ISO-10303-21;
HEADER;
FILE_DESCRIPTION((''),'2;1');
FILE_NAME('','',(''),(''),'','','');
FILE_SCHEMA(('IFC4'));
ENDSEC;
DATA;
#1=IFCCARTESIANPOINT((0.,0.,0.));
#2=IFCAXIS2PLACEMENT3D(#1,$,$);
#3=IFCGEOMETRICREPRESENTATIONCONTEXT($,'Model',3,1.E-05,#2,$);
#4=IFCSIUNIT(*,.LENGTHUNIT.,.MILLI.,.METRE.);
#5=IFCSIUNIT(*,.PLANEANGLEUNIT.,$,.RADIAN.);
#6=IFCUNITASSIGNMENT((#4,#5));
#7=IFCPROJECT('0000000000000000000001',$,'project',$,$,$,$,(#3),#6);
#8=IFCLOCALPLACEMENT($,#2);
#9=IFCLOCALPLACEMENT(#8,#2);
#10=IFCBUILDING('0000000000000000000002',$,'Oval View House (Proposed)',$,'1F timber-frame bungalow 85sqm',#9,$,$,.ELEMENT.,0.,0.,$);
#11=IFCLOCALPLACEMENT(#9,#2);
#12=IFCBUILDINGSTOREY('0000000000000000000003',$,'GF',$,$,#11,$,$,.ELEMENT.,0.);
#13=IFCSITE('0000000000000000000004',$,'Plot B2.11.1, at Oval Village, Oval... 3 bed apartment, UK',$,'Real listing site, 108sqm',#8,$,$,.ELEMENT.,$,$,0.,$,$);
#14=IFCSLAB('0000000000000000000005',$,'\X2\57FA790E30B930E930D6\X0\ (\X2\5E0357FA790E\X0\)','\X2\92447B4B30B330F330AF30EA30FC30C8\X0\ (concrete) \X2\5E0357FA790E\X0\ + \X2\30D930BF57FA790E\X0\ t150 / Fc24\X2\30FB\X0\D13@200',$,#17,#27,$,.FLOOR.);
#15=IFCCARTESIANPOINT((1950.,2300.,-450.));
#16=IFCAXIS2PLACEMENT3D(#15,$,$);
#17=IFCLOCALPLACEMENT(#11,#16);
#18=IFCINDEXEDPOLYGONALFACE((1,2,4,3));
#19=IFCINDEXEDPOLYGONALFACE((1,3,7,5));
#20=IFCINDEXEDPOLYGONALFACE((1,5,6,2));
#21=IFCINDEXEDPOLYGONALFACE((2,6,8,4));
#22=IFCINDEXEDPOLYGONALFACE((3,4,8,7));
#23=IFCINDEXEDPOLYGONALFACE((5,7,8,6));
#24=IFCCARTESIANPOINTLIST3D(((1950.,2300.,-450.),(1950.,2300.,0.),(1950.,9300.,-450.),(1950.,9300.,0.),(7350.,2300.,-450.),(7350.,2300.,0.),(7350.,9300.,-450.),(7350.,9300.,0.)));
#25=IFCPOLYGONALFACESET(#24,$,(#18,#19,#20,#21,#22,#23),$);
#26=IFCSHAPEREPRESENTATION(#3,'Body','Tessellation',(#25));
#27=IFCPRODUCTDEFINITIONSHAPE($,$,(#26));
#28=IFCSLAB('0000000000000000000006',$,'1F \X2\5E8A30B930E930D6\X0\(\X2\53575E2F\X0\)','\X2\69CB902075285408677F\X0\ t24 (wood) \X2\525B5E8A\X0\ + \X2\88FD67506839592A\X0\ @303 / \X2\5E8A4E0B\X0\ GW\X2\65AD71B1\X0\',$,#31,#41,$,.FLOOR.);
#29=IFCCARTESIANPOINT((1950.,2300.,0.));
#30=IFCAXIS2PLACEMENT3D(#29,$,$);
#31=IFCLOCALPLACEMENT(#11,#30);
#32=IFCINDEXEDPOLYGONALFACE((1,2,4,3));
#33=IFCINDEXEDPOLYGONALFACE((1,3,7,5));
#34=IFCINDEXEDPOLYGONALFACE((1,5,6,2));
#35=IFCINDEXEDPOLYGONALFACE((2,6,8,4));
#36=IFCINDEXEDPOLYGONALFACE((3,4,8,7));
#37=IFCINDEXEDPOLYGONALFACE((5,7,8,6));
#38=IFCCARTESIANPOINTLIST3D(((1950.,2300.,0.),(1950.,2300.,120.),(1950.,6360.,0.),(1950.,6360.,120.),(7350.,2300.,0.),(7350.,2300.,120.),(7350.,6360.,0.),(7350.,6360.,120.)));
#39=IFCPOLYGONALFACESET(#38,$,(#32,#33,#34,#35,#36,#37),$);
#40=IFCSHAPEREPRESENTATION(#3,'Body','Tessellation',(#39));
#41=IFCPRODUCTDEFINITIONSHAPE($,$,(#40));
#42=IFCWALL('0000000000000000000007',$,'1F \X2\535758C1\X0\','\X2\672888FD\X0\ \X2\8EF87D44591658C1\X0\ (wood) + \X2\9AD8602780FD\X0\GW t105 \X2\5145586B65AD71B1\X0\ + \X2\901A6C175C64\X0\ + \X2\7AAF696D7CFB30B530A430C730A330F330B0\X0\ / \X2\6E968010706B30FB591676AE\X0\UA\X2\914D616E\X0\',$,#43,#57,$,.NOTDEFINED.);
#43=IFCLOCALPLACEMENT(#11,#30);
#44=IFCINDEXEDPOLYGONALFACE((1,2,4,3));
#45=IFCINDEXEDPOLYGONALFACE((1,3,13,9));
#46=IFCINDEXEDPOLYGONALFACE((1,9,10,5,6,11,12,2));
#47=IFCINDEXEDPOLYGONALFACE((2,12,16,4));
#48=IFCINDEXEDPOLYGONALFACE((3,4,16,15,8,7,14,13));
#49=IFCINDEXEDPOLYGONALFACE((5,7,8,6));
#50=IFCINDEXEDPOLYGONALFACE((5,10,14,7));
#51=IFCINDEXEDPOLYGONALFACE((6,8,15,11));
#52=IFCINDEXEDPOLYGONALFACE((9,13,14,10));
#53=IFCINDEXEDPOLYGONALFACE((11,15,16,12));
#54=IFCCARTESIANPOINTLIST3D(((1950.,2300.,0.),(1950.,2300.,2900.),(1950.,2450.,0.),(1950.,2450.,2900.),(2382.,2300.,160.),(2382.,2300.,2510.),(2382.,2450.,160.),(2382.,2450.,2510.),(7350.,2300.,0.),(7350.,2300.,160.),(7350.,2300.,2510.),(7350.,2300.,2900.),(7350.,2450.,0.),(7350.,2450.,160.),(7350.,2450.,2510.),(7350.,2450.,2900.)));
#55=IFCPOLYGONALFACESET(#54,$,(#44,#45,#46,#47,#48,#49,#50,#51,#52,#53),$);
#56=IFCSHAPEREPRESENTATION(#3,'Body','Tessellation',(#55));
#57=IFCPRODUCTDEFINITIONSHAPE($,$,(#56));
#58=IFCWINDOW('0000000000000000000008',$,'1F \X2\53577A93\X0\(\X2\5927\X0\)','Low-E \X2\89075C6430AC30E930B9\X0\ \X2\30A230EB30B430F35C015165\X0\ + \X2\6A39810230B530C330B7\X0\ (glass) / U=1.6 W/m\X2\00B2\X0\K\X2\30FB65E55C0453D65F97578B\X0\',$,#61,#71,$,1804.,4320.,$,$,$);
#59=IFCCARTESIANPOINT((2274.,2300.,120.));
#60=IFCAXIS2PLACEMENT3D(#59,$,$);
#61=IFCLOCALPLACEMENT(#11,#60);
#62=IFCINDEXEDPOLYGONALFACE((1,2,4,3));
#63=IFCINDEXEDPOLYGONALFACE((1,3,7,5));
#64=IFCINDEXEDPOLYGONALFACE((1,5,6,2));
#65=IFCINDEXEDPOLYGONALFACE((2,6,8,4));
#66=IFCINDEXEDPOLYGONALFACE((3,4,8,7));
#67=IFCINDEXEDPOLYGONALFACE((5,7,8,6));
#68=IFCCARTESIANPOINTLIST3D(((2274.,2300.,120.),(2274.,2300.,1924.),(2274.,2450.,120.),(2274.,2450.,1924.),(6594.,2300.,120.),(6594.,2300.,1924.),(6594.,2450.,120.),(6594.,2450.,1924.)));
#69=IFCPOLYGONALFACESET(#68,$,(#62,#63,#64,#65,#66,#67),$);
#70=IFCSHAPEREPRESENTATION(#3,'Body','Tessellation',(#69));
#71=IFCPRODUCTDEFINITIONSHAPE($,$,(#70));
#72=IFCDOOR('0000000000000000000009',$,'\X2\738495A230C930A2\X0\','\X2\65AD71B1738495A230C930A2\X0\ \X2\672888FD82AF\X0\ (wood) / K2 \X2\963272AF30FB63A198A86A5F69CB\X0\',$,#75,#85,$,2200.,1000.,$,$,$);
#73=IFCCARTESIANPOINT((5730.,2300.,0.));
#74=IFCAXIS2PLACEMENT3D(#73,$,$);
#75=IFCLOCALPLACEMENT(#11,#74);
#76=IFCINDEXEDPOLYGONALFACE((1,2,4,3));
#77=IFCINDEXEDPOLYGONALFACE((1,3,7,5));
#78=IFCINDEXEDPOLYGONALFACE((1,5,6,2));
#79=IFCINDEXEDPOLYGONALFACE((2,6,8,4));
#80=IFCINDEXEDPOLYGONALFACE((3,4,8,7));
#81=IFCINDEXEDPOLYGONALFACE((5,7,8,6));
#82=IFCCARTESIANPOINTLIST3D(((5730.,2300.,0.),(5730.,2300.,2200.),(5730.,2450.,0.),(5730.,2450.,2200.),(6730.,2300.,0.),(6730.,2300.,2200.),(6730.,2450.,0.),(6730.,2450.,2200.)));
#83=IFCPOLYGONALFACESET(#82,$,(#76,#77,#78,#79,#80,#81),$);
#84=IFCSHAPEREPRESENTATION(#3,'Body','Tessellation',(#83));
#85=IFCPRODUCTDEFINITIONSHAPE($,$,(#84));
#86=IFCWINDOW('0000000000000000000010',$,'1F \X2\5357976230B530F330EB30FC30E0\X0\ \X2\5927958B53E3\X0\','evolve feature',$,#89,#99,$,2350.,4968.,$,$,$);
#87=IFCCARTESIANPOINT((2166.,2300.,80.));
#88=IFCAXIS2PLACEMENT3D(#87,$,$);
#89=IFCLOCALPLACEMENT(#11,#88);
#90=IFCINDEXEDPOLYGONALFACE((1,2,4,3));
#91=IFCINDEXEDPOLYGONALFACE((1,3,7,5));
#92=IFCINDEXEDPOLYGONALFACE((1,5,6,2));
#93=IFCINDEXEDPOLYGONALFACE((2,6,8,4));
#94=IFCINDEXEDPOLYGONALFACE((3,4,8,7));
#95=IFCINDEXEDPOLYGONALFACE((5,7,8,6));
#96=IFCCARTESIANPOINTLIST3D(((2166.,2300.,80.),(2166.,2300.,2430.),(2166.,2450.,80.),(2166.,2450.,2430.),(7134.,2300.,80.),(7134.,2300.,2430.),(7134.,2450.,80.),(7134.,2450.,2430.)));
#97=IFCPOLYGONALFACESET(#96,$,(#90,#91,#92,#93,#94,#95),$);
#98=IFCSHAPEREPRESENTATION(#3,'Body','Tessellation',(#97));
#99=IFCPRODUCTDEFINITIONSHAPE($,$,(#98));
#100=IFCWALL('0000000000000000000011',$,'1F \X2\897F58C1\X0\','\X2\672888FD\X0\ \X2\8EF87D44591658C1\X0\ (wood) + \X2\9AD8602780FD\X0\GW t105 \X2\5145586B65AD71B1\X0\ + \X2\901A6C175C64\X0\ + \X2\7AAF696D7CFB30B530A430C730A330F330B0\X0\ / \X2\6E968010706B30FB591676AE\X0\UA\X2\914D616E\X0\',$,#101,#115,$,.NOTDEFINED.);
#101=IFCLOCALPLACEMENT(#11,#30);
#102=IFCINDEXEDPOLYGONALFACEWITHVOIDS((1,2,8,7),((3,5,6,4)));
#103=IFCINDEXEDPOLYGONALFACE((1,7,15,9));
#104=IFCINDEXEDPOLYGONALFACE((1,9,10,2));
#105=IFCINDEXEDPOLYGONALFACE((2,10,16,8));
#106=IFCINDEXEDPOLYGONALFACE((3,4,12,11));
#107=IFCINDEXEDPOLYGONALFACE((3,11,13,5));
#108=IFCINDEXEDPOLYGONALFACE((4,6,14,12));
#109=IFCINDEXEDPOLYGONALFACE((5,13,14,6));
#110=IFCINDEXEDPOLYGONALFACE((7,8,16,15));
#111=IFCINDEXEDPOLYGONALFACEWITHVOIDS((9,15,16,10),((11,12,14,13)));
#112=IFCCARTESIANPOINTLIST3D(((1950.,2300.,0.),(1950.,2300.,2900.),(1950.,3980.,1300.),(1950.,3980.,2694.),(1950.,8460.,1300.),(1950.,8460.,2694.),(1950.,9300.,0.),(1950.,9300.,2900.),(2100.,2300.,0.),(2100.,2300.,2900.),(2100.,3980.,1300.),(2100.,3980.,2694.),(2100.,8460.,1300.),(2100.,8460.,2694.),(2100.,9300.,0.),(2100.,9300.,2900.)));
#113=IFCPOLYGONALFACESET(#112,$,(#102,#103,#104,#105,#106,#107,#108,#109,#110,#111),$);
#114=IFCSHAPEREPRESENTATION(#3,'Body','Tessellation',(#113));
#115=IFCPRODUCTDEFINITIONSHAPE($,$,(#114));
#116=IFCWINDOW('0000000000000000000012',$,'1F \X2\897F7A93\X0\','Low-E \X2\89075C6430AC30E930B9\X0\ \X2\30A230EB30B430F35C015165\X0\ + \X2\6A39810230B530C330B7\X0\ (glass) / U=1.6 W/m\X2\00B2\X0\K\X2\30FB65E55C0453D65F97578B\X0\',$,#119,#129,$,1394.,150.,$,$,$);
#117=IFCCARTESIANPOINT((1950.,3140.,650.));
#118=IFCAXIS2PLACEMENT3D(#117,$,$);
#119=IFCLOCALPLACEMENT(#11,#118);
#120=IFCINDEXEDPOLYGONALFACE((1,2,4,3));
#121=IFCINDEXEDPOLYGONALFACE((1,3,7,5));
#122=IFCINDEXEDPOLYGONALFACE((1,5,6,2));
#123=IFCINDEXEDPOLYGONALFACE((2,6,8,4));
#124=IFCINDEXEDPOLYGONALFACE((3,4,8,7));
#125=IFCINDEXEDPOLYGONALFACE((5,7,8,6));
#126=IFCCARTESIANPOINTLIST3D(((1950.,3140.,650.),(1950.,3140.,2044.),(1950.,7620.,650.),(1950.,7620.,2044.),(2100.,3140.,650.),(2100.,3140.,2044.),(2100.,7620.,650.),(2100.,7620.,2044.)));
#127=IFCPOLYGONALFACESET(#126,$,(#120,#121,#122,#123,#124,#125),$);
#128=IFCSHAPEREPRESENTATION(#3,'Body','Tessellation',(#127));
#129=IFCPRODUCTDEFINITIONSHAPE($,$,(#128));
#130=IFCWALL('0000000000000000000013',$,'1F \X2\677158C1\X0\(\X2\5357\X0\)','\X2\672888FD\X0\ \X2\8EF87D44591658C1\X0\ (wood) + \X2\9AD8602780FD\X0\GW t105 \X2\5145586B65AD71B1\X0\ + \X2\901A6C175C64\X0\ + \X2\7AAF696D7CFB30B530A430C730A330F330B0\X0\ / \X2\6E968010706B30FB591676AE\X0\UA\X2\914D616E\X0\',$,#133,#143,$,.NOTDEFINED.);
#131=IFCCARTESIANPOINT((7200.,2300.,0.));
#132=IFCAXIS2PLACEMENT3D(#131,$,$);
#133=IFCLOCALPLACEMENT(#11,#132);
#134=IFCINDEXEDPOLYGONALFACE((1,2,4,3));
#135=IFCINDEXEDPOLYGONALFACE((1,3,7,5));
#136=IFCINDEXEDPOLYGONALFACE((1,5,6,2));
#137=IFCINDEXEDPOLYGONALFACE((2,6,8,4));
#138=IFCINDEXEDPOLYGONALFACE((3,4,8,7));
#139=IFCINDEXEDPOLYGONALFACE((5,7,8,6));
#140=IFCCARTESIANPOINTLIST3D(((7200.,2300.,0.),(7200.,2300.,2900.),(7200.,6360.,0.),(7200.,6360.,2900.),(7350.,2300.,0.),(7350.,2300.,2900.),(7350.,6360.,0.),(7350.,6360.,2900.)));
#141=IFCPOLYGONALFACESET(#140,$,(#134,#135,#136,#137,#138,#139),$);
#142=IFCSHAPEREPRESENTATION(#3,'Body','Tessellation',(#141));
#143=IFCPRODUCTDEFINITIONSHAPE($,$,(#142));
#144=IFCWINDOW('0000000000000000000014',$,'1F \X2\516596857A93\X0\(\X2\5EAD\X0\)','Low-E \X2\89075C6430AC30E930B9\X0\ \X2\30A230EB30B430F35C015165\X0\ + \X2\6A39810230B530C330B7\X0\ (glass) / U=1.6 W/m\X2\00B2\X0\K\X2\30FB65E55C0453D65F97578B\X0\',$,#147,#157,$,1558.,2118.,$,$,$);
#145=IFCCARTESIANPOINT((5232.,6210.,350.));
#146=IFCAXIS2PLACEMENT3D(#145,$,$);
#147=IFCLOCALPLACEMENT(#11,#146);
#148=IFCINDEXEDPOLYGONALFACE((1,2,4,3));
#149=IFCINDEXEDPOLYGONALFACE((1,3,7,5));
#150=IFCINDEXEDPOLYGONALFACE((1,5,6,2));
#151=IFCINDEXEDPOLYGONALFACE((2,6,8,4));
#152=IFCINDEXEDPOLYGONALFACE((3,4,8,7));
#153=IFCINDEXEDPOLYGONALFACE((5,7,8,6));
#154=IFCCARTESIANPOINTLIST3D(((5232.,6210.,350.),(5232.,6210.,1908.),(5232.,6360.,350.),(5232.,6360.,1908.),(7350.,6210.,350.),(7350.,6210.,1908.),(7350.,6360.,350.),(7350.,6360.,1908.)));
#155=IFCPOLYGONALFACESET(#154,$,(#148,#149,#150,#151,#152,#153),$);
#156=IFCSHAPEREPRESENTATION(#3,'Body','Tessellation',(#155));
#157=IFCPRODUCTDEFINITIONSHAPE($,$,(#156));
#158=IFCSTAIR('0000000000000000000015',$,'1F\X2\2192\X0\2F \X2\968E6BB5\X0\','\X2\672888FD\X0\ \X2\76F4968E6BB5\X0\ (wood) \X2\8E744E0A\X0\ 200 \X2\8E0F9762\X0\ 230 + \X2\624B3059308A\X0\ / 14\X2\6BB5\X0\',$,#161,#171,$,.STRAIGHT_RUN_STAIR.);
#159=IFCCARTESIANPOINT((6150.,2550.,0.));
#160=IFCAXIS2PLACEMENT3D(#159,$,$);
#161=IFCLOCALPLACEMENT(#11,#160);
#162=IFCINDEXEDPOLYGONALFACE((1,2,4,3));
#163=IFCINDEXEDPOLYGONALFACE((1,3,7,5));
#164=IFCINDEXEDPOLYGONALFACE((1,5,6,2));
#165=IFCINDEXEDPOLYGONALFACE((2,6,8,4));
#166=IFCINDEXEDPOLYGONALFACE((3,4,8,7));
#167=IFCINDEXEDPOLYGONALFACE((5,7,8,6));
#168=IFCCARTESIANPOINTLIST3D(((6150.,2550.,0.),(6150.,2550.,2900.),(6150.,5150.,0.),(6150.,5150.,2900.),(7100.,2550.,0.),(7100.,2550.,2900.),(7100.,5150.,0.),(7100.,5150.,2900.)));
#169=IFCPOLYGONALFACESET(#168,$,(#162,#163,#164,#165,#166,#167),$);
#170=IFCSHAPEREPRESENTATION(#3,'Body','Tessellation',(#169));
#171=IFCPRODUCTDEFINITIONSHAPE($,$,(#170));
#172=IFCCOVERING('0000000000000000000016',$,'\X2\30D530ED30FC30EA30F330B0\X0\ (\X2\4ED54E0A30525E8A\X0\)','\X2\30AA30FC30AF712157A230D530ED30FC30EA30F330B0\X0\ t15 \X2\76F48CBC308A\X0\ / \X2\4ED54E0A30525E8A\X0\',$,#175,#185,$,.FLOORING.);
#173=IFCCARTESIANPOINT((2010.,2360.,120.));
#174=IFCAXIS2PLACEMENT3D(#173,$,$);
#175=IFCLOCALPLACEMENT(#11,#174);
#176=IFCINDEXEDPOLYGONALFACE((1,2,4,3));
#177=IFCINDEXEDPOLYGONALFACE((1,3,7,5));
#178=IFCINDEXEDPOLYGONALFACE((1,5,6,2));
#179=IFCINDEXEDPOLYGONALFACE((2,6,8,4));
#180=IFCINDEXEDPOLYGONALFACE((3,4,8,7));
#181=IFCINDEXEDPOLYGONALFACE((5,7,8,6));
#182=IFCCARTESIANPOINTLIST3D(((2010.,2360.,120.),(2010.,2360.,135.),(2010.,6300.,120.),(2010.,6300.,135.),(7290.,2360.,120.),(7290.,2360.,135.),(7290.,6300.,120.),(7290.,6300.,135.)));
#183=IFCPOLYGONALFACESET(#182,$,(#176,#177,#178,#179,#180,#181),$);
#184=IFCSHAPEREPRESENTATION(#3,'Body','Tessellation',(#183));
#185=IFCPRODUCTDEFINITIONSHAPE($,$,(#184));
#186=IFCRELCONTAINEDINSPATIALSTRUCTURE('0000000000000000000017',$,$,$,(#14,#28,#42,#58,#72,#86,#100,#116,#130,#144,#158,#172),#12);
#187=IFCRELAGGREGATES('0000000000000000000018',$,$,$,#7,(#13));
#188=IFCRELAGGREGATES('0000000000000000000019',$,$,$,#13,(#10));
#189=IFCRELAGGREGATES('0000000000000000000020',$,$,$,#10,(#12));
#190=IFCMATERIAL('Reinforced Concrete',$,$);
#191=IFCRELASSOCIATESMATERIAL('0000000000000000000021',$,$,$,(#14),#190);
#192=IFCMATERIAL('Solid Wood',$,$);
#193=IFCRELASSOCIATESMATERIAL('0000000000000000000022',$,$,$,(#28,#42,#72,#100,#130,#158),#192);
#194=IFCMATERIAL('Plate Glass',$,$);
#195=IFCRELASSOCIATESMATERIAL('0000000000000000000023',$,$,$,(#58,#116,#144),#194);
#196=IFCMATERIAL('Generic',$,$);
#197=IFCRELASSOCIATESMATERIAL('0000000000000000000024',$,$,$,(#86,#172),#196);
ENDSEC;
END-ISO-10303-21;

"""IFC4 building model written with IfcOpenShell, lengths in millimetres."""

from ifc_helpers import new_model, si_unit, frame, frame_2d, origin, place, context, project, spatial, rectangle, extrude, material, element, fill, save


model = new_model("IFC4")

# Units and contexts
model_context = context("Model", 3, precision=1e-05, world=origin())
ifc_project = project(units=[si_unit("LENGTHUNIT", "METRE", prefix="MILLI"), si_unit("PLANEANGLEUNIT", "RADIAN")], contexts=[model_context])

# Site, building, storey
site_placement = place(None, origin())
site = spatial("IfcSite", under=ifc_project, at=site_placement, Name="Plot B2.11.1, at Oval Village, Oval... 3 bed apartment, UK", ObjectType="Real listing site, 108sqm", CompositionType="ELEMENT", RefElevation=0.0)
building_placement = place(site_placement, origin())
building = spatial("IfcBuilding", under=site, at=building_placement, Name="Oval View House (Proposed)", ObjectType="1F timber-frame bungalow 85sqm", CompositionType="ELEMENT", ElevationOfRefHeight=0.0, ElevationOfTerrain=0.0)
storey_placement = place(building_placement, origin())
storey = spatial("IfcBuildingStorey", under=building, at=storey_placement, Name="GF", CompositionType="ELEMENT", Elevation=0.0)

# Slabs
ifc_material_1 = material(Name="Reinforced Concrete")
slab_1_placement = place(storey_placement, frame((1950.0, 2300.0, -450.0)))
element("IfcSlab", 1, at=slab_1_placement, inside=storey, material=ifc_material_1, Name="基礎スラブ (布基礎)", Description="鉄筋コンクリート (concrete) 布基礎 + ベタ基礎 t150 / Fc24・D13@200", PredefinedType="FLOOR", context=model_context, shape_type="SweptSolid", body=[
    extrude(rectangle(XDim=5400.0, YDim=7000.0, at=frame_2d((2700.0, 3500.0))), frame((1950.0, 2300.0, -450.0)), (0.0, 0.0, 1.0), 450.0),
])
ifc_material_2 = material(Name="Solid Wood")
slab_2_placement = place(storey_placement, frame((1950.0, 2300.0, 0.0)))
element("IfcSlab", 2, at=slab_2_placement, inside=storey, material=ifc_material_2, Name="1F 床スラブ(南帯)", Description="構造用合板 t24 (wood) 剛床 + 製材根太 @303 / 床下 GW断熱", PredefinedType="FLOOR", context=model_context, shape_type="SweptSolid", body=[
    extrude(rectangle(XDim=5400.0, YDim=4060.0, at=frame_2d((2700.0, 2030.0))), frame((1950.0, 2300.0, 0.0)), (0.0, 0.0, 1.0), 120.0),
])

# Wall, openings, windows, door
wall_1_placement = place(storey_placement, frame((1950.0, 2300.0, 0.0)))
wall_1 = element("IfcWall", 3, at=wall_1_placement, inside=storey, material=ifc_material_2, Name="1F 南壁", Description="木製 軸組外壁 (wood) + 高性能GW t105 充填断熱 + 通気層 + 窯業系サイディング / 準耐火・外皮UA配慮", PredefinedType="NOTDEFINED", context=model_context, shape_type="SweptSolid", body=[
    extrude(rectangle(XDim=5400.0, YDim=150.0, at=frame_2d((2700.0, 75.0))), frame((1950.0, 2300.0, 0.0)), (0.0, 0.0, 1.0), 2900.0),
])
opening_1_placement = place(storey_placement, frame((2274.0, 2300.0, 120.0)))
opening_1 = element("IfcOpeningElement", 4, at=opening_1_placement, cuts=wall_1, PredefinedType="NOTDEFINED", context=model_context, shape_type="SweptSolid", body=[
    extrude(rectangle(XDim=4320.0, YDim=150.0, at=frame_2d((2160.0, 75.0))), frame((2274.0, 2300.0, 120.0)), (0.0, 0.0, 1.0), 1804.0),
])
opening_2_placement = place(storey_placement, frame((5730.0, 2300.0, 0.0)))
opening_2 = element("IfcOpeningElement", 5, at=opening_2_placement, cuts=wall_1, PredefinedType="NOTDEFINED", context=model_context, shape_type="SweptSolid", body=[
    extrude(rectangle(XDim=1000.0, YDim=150.0, at=frame_2d((500.0, 75.0))), frame((5730.0, 2300.0, 0.0)), (0.0, 0.0, 1.0), 2200.0),
])
opening_3_placement = place(storey_placement, frame((2166.0, 2300.0, 80.0)))
opening_3 = element("IfcOpeningElement", 6, at=opening_3_placement, cuts=wall_1, PredefinedType="NOTDEFINED", context=model_context, shape_type="SweptSolid", body=[
    extrude(rectangle(XDim=4968.0, YDim=150.0, at=frame_2d((2484.0, 75.0))), frame((2166.0, 2300.0, 80.0)), (0.0, 0.0, 1.0), 2350.0),
])
ifc_material_3 = material(Name="Plate Glass")
window_1_placement = place(storey_placement, frame((2274.0, 2300.0, 120.0)))
window_1 = element("IfcWindow", 7, at=window_1_placement, inside=storey, material=ifc_material_3, Name="1F 南窓(大)", Description="Low-E 複層ガラス アルゴン封入 + 樹脂サッシ (glass) / U=1.6 W/m²K・日射取得型", OverallHeight=1804.0, OverallWidth=4320.0, context=model_context, shape_type="SweptSolid", body=[
    extrude(rectangle(XDim=4320.0, YDim=150.0, at=frame_2d((2160.0, 75.0))), frame((2274.0, 2300.0, 120.0)), (0.0, 0.0, 1.0), 1804.0),
])
fill(opening_1, window_1)
door_1_placement = place(storey_placement, frame((5730.0, 2300.0, 0.0)))
door_1 = element("IfcDoor", 8, at=door_1_placement, inside=storey, material=ifc_material_2, Name="玄関ドア", Description="断熱玄関ドア 木製芯 (wood) / K2 防犯・採風機構", OverallHeight=2200.0, OverallWidth=1000.0, context=model_context, shape_type="SweptSolid", body=[
    extrude(rectangle(XDim=1000.0, YDim=150.0, at=frame_2d((500.0, 75.0))), frame((5730.0, 2300.0, 0.0)), (0.0, 0.0, 1.0), 2200.0),
])
fill(opening_2, door_1)
ifc_material_4 = material(Name="Generic")
window_2_placement = place(storey_placement, frame((2166.0, 2300.0, 80.0)))
window_2 = element("IfcWindow", 9, at=window_2_placement, inside=storey, material=ifc_material_4, Name="1F 南面サンルーム 大開口", Description="evolve feature", OverallHeight=2350.0, OverallWidth=4968.0, context=model_context, shape_type="SweptSolid", body=[
    extrude(rectangle(XDim=4968.0, YDim=150.0, at=frame_2d((2484.0, 75.0))), frame((2166.0, 2300.0, 80.0)), (0.0, 0.0, 1.0), 2350.0),
])
fill(opening_3, window_2)

# Walls, openings, windows
wall_2_placement = place(storey_placement, frame((1950.0, 2300.0, 0.0)))
wall_2 = element("IfcWall", 10, at=wall_2_placement, inside=storey, material=ifc_material_2, Name="1F 西壁", Description="木製 軸組外壁 (wood) + 高性能GW t105 充填断熱 + 通気層 + 窯業系サイディング / 準耐火・外皮UA配慮", PredefinedType="NOTDEFINED", context=model_context, shape_type="SweptSolid", body=[
    extrude(rectangle(XDim=150.0, YDim=7000.0, at=frame_2d((75.0, 3500.0))), frame((1950.0, 2300.0, 0.0)), (0.0, 0.0, 1.0), 2900.0),
])
opening_4_placement = place(storey_placement, frame((1950.0, 3140.0, 650.0)))
opening_4 = element("IfcOpeningElement", 11, at=opening_4_placement, cuts=wall_2, PredefinedType="NOTDEFINED", context=model_context, shape_type="SweptSolid", body=[
    extrude(rectangle(XDim=150.0, YDim=4480.0, at=frame_2d((75.0, 2240.0))), frame((1950.0, 3140.0, 650.0)), (0.0, 0.0, 1.0), 1394.0),
])
window_3_placement = place(storey_placement, frame((1950.0, 3140.0, 650.0)))
window_3 = element("IfcWindow", 12, at=window_3_placement, inside=storey, material=ifc_material_3, Name="1F 西窓", Description="Low-E 複層ガラス アルゴン封入 + 樹脂サッシ (glass) / U=1.6 W/m²K・日射取得型", OverallHeight=1394.0, OverallWidth=150.0, context=model_context, shape_type="SweptSolid", body=[
    extrude(rectangle(XDim=150.0, YDim=4480.0, at=frame_2d((75.0, 2240.0))), frame((1950.0, 3140.0, 650.0)), (0.0, 0.0, 1.0), 1394.0),
])
fill(opening_4, window_3)
wall_3_placement = place(storey_placement, frame((7200.0, 2300.0, 0.0)))
wall_3 = element("IfcWall", 13, at=wall_3_placement, inside=storey, material=ifc_material_2, Name="1F 東壁(南)", Description="木製 軸組外壁 (wood) + 高性能GW t105 充填断熱 + 通気層 + 窯業系サイディング / 準耐火・外皮UA配慮", PredefinedType="NOTDEFINED", context=model_context, shape_type="SweptSolid", body=[
    extrude(rectangle(XDim=150.0, YDim=4060.0, at=frame_2d((75.0, 2030.0))), frame((7200.0, 2300.0, 0.0)), (0.0, 0.0, 1.0), 2900.0),
])
opening_5_placement = place(storey_placement, frame((5232.0, 6210.0, 350.0)))
opening_5 = element("IfcOpeningElement", 14, at=opening_5_placement, cuts=wall_3, PredefinedType="NOTDEFINED", context=model_context, shape_type="SweptSolid", body=[
    extrude(rectangle(XDim=2118.0, YDim=150.0, at=frame_2d((1059.0, 75.0))), frame((5232.0, 6210.0, 350.0)), (0.0, 0.0, 1.0), 1558.0),
])
window_4_placement = place(storey_placement, frame((5232.0, 6210.0, 350.0)))
window_4 = element("IfcWindow", 15, at=window_4_placement, inside=storey, material=ifc_material_3, Name="1F 入隅窓(庭)", Description="Low-E 複層ガラス アルゴン封入 + 樹脂サッシ (glass) / U=1.6 W/m²K・日射取得型", OverallHeight=1558.0, OverallWidth=2118.0, context=model_context, shape_type="SweptSolid", body=[
    extrude(rectangle(XDim=2118.0, YDim=150.0, at=frame_2d((1059.0, 75.0))), frame((5232.0, 6210.0, 350.0)), (0.0, 0.0, 1.0), 1558.0),
])
fill(opening_5, window_4)

# Stair
stair_placement = place(storey_placement, frame((6150.0, 2550.0, 0.0)))
element("IfcStair", 16, at=stair_placement, inside=storey, material=ifc_material_2, Name="1F→2F 階段", Description="木製 直階段 (wood) 蹴上 200 踏面 230 + 手すり / 14段", PredefinedType="STRAIGHT_RUN_STAIR", context=model_context, shape_type="SweptSolid", body=[
    extrude(rectangle(XDim=950.0, YDim=2600.0, at=frame_2d((475.0, 1300.0))), frame((6150.0, 2550.0, 0.0)), (0.0, 0.0, 1.0), 2900.0),
])

# Covering
covering_placement = place(storey_placement, frame((2010.0, 2360.0, 120.0)))
element("IfcCovering", 17, at=covering_placement, inside=storey, material=ifc_material_4, Name="フローリング (仕上げ床)", Description="オーク無垢フローリング t15 直貼り / 仕上げ床", PredefinedType="FLOORING", context=model_context, shape_type="SweptSolid", body=[
    extrude(rectangle(XDim=5280.0, YDim=3940.0, at=frame_2d((2640.0, 1970.0))), frame((2010.0, 2360.0, 120.0)), (0.0, 0.0, 1.0), 15.0),
])

save(model, "model.ifc")
